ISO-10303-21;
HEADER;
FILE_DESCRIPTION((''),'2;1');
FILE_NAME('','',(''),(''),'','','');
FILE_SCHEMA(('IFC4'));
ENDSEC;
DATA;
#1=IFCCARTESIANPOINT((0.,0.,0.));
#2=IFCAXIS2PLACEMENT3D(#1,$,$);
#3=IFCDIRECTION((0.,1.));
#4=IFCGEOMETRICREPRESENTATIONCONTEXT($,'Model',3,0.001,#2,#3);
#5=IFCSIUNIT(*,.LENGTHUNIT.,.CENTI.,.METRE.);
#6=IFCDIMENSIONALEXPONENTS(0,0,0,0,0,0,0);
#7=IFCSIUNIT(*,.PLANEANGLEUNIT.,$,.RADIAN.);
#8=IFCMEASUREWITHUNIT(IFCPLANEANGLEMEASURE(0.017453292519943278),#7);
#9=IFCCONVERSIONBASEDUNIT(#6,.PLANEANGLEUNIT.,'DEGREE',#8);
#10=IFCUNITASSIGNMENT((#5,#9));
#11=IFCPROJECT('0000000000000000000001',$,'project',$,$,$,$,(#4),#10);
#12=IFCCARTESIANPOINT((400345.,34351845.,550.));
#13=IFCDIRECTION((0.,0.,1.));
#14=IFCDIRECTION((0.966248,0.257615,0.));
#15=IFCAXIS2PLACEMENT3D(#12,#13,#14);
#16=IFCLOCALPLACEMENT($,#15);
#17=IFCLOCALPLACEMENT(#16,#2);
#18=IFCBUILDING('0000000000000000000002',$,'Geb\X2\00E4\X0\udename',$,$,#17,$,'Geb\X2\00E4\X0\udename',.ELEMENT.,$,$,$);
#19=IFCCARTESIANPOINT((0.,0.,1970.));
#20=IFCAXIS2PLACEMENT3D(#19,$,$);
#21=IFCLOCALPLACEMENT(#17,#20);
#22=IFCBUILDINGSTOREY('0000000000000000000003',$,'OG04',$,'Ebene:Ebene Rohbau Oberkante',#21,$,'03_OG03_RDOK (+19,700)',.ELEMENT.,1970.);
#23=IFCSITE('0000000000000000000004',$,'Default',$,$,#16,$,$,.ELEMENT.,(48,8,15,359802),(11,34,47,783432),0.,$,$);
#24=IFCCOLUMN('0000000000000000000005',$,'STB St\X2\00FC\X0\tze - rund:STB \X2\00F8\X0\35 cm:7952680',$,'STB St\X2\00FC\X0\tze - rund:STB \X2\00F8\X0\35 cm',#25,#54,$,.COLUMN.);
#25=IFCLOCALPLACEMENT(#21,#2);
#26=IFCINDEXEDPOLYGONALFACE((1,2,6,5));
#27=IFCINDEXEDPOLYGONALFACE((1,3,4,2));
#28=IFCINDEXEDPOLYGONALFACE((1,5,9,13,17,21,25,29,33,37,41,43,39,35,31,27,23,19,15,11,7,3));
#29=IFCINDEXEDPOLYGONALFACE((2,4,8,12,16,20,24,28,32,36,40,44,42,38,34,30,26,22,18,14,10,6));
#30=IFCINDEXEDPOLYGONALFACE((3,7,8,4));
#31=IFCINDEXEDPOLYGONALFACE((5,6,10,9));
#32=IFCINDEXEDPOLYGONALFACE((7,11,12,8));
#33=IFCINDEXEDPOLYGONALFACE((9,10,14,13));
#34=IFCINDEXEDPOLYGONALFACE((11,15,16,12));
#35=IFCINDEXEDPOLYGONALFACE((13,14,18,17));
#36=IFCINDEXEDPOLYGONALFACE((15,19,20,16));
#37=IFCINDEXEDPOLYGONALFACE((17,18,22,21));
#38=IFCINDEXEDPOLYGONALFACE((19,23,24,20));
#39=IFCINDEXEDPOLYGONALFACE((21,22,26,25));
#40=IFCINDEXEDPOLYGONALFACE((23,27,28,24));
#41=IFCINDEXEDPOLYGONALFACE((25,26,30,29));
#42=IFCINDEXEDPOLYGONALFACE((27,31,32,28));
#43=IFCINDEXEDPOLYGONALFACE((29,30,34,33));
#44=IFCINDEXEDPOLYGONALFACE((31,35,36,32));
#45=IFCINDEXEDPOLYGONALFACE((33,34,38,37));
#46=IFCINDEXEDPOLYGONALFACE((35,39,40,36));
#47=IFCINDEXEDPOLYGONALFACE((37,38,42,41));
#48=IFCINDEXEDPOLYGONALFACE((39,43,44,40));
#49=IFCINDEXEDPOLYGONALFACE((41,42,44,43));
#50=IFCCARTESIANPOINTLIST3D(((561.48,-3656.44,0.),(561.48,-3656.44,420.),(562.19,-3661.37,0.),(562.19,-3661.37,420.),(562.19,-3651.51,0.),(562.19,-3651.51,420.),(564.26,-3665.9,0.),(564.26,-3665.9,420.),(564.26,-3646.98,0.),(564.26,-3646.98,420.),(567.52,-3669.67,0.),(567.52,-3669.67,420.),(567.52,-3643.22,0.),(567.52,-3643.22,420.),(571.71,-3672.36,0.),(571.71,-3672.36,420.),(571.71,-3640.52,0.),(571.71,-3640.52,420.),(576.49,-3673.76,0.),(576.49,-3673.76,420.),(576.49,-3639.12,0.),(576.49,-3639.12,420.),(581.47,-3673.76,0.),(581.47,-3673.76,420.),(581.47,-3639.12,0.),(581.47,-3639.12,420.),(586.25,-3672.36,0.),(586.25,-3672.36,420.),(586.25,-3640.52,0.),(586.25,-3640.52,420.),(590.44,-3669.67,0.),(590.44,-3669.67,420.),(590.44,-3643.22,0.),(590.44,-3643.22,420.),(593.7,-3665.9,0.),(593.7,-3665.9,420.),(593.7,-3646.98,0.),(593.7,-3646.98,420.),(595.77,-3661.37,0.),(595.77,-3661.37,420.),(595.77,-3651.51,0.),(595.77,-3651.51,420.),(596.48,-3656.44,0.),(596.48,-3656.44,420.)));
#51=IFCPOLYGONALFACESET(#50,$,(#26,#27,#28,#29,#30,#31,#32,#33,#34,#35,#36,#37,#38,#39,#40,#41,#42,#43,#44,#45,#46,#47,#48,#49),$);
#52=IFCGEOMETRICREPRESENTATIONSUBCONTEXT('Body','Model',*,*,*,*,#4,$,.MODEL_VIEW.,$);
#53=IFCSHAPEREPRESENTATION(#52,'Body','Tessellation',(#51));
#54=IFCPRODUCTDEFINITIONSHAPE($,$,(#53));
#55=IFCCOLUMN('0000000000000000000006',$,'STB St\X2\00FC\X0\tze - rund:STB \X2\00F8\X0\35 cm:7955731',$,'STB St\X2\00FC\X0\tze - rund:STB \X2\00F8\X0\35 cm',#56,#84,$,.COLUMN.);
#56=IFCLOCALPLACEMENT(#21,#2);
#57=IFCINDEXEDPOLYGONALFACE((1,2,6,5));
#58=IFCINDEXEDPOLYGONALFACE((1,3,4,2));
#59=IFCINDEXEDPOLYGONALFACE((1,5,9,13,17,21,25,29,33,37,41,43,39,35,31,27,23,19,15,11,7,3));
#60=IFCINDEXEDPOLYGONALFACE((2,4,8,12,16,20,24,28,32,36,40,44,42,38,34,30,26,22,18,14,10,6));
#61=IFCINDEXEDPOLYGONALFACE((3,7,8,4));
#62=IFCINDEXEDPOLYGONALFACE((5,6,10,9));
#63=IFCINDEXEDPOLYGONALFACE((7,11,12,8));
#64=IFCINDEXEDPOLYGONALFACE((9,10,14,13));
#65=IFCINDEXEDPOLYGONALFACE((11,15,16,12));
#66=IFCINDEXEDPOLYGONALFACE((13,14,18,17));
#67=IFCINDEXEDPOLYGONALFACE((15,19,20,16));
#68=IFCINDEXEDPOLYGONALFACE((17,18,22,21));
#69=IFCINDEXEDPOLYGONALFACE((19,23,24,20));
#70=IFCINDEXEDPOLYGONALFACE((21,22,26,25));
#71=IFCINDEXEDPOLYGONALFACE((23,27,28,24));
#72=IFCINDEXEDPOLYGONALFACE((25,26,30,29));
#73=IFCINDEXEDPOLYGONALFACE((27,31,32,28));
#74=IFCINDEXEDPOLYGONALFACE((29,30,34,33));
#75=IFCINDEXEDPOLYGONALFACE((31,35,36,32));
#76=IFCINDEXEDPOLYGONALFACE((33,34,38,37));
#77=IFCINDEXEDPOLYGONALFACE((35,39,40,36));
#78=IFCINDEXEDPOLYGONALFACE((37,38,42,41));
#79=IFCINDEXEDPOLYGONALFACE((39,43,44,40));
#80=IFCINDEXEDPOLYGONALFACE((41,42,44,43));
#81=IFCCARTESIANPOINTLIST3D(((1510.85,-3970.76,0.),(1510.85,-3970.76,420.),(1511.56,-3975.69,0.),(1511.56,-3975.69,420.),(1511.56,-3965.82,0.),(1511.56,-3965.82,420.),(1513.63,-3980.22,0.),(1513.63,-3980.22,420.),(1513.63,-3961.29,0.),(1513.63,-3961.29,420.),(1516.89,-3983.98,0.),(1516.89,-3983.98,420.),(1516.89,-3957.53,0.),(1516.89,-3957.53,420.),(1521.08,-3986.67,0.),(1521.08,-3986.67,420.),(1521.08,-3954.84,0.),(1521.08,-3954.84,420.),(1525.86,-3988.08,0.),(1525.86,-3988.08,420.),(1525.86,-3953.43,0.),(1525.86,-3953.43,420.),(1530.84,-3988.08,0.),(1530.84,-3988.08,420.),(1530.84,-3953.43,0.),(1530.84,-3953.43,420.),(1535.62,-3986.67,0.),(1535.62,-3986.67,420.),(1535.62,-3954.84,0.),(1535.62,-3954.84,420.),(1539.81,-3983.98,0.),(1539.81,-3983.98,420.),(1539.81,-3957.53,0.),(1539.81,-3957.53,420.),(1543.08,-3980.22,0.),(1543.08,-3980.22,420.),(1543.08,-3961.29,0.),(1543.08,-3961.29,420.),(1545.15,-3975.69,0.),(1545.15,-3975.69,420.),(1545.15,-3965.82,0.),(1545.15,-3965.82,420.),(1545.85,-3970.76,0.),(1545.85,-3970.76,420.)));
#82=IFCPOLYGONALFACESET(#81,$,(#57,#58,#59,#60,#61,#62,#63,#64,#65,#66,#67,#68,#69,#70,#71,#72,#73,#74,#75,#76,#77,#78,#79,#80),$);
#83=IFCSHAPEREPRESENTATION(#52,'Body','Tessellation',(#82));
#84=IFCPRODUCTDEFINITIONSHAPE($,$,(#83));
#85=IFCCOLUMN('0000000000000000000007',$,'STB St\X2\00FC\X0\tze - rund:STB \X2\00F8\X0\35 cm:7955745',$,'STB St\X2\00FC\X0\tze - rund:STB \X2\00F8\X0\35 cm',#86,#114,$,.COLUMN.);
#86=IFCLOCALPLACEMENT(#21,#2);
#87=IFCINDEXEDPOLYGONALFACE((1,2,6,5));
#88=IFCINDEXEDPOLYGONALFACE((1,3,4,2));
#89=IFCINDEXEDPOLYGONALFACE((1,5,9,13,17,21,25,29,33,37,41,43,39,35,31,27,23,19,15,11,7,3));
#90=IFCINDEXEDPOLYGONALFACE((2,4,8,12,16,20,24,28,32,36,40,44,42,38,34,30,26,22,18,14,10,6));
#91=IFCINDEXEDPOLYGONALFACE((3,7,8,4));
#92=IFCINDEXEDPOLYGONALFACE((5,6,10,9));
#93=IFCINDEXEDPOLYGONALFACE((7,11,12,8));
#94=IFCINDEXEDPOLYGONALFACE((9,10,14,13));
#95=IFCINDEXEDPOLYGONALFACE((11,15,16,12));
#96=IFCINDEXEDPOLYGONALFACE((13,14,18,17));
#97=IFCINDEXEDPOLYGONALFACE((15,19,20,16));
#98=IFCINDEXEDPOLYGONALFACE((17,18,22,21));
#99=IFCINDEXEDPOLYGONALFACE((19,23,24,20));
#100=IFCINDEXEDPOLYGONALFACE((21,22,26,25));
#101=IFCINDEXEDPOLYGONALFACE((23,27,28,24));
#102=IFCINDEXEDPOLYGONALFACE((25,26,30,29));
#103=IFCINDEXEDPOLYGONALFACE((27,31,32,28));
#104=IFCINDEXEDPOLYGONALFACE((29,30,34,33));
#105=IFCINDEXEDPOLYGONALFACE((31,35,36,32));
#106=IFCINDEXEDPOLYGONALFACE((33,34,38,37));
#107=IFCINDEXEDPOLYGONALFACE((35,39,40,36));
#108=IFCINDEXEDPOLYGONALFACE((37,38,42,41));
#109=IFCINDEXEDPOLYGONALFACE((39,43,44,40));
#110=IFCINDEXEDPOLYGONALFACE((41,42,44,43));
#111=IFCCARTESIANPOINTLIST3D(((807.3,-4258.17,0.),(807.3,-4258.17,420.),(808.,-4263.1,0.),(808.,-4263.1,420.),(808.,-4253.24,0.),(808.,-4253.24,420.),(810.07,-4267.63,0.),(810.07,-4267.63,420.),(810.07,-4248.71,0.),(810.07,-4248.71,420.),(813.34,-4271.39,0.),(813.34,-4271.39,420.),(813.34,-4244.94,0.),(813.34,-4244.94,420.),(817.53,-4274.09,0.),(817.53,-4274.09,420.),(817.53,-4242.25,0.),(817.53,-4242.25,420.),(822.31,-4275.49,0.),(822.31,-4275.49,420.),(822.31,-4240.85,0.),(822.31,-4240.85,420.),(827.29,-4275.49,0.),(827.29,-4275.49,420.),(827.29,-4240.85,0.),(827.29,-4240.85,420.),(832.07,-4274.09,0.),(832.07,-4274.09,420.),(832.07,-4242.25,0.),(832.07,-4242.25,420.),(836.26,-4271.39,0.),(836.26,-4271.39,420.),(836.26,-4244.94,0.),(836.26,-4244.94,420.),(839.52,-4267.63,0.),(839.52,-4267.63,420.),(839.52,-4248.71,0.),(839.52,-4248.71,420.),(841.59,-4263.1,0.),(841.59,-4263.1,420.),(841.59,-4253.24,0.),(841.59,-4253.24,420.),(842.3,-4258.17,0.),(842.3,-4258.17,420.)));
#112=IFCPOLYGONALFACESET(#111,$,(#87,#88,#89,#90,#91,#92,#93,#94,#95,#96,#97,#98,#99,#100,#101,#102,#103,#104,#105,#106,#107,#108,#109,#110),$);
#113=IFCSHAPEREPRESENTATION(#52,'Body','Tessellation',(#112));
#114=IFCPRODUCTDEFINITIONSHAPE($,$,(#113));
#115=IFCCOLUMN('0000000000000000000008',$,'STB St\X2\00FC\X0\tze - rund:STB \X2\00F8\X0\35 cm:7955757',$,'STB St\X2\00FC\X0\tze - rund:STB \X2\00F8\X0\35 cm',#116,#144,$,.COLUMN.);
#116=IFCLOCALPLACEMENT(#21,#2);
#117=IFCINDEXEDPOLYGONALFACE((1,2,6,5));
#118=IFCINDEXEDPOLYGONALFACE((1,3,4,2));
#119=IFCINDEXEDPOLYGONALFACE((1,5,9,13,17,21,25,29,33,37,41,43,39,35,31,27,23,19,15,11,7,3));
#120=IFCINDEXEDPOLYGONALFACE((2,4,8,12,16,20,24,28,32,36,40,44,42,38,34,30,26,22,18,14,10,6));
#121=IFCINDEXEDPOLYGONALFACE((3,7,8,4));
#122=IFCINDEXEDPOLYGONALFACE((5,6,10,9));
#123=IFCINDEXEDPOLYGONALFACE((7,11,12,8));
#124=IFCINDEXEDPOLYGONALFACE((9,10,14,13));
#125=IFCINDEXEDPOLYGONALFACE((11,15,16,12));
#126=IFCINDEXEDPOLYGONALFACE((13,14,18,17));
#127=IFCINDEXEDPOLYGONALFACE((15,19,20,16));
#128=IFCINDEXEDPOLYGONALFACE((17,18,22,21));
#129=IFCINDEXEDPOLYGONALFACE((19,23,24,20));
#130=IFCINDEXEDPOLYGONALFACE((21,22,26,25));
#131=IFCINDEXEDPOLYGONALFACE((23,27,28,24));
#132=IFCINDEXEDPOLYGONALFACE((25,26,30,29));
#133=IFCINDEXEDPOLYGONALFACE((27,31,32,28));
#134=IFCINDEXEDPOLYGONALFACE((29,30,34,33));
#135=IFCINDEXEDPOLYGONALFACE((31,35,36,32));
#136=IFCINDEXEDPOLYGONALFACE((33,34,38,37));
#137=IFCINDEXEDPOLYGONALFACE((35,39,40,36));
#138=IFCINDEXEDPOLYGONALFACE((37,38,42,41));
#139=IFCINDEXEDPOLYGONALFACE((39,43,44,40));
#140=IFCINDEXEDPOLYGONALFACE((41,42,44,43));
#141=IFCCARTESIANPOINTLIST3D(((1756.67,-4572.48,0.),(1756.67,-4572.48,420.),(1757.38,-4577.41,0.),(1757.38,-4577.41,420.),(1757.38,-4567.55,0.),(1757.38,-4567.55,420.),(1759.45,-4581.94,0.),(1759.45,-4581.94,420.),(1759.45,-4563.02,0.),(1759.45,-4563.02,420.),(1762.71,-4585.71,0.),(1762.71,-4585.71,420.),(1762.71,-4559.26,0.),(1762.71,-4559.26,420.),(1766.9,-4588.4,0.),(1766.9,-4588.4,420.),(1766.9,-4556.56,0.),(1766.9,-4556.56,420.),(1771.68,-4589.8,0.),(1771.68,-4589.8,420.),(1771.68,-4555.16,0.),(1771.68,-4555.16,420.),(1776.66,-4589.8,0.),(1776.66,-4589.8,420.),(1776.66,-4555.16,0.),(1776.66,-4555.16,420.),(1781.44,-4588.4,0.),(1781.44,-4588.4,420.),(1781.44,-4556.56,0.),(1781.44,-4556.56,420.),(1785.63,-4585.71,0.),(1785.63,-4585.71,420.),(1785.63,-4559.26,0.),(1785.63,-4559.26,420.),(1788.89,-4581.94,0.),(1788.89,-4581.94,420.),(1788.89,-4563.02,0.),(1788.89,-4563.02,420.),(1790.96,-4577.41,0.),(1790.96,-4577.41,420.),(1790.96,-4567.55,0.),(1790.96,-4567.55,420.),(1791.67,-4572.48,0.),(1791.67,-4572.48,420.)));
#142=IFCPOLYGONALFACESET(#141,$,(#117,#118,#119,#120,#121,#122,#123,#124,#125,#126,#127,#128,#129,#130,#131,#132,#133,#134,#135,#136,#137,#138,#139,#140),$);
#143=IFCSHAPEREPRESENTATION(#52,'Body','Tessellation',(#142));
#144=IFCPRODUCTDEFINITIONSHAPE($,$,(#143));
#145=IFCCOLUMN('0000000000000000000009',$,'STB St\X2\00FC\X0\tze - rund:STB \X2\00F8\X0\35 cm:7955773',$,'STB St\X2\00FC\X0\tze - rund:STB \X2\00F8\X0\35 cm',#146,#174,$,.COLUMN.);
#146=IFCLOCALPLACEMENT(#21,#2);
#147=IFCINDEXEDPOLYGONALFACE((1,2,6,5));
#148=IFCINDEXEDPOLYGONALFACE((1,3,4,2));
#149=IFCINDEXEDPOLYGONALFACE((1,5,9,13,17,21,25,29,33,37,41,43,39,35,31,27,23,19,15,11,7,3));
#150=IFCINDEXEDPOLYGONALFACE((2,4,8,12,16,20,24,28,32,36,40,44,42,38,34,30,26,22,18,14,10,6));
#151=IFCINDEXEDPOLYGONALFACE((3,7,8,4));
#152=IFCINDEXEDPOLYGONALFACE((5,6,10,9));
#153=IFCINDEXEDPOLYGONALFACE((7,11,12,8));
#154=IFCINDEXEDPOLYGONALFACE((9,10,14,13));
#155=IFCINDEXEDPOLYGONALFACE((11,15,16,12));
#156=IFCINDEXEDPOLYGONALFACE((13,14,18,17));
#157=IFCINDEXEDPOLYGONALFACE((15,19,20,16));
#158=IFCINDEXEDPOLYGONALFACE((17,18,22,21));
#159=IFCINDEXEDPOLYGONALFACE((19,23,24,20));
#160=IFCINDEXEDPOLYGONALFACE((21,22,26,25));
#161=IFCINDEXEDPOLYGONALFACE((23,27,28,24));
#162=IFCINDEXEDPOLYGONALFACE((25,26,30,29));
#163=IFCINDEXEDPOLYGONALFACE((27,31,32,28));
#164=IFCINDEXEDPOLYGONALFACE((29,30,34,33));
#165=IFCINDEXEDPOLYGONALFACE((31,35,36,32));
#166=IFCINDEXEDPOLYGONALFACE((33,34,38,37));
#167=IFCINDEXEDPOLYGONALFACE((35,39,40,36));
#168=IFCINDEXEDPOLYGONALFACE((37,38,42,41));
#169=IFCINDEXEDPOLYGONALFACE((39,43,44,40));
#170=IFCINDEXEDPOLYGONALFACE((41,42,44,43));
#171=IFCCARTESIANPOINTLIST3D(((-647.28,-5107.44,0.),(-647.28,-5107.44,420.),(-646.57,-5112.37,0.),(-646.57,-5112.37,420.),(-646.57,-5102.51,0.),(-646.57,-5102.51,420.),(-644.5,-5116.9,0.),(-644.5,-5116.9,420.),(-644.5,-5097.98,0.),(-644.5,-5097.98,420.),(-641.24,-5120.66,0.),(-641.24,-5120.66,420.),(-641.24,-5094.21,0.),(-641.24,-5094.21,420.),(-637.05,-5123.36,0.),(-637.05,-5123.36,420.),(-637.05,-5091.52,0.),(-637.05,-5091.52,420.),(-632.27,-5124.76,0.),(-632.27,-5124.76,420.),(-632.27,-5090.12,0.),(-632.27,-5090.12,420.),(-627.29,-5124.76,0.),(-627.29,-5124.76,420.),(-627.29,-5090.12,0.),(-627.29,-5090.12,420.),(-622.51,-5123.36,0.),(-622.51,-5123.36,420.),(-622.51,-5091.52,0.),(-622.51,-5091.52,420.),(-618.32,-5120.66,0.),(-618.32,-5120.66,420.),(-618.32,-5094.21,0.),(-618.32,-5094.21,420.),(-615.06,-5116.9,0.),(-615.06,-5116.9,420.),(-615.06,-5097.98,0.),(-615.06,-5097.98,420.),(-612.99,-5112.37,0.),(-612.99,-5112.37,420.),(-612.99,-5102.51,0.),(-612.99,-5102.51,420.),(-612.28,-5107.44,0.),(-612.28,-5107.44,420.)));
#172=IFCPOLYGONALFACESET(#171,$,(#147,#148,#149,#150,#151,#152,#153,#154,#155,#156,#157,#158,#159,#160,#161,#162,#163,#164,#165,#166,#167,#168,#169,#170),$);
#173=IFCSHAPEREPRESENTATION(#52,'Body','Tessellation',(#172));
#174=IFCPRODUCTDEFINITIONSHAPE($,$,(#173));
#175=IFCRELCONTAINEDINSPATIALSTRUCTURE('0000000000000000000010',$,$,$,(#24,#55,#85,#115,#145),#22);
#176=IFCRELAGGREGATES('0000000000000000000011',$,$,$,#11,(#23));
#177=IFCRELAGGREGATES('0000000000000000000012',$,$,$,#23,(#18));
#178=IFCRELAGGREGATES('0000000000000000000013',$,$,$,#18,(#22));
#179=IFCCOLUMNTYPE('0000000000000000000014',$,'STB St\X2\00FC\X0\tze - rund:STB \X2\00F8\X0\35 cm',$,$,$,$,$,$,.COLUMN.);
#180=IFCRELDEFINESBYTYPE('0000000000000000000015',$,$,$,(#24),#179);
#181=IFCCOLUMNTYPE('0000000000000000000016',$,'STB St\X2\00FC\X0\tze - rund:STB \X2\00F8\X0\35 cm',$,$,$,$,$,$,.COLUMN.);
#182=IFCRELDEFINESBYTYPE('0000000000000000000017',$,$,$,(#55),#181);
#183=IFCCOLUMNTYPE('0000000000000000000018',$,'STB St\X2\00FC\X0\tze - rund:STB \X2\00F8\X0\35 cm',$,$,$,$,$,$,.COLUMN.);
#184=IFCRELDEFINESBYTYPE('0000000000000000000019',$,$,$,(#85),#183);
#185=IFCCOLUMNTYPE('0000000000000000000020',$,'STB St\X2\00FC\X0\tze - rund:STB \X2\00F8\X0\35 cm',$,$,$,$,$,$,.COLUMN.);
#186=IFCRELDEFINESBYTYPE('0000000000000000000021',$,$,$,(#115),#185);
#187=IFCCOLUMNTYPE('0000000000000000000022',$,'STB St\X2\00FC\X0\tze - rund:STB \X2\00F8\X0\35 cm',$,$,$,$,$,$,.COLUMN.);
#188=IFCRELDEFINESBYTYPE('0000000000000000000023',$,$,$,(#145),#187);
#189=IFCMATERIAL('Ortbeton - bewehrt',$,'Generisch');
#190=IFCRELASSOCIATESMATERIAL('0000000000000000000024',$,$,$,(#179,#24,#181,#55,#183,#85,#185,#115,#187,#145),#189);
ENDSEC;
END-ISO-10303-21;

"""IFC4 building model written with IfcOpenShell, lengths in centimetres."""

from ifc_helpers import new_model, entity, si_unit, converted_unit, direction, frame, origin, place, context, subcontext, project, spatial, arc, indexed_curve, outline, extrude, source, transform, mapped, material, type_object, type_shapes, element, save


model = new_model("IFC4")

# Units and contexts
model_context = context("Model", 3, precision=0.001, world=origin(), true_north=direction((0.0, 1.0)))
body_context = subcontext(model_context, "Body", "Model", "MODEL_VIEW")
ifc_project = project(units=[si_unit("LENGTHUNIT", "METRE", prefix="CENTI"), converted_unit("PLANEANGLEUNIT", "DEGREE", entity("IfcPlaneAngleMeasure", 0.017453292519943278), si_unit("PLANEANGLEUNIT", "RADIAN"), dimensions=[0, 0, 0, 0, 0, 0, 0])], contexts=[model_context])

# Site, building, storey
site_placement = place(None, frame((400345.0, 34351845.0, 550.0), z_axis=(0.0, 0.0, 1.0), x_axis=(0.966248, 0.257615, 0.0)))
site = spatial("IfcSite", under=ifc_project, at=site_placement, Name="Default", CompositionType="ELEMENT", RefLatitude=(48, 8, 15, 359802), RefLongitude=(11, 34, 47, 783432), RefElevation=0.0)
building_placement = place(site_placement, origin())
building = spatial("IfcBuilding", under=site, at=building_placement, Name="Gebäudename", LongName="Gebäudename", CompositionType="ELEMENT")
storey_placement = place(building_placement, frame((0.0, 0.0, 1970.0)))
storey = spatial("IfcBuildingStorey", under=building, at=storey_placement, Name="OG04", ObjectType="Ebene:Ebene Rohbau Oberkante", LongName="03_OG03_RDOK (+19,700)", CompositionType="ELEMENT", Elevation=1970.0)

# Columns
ifc_material = material(Name="Ortbeton - bewehrt", Category="Generisch")
column_type_1 = type_object("IfcColumnType", Name="STB Stütze - rund:STB ø35 cm", PredefinedType="COLUMN", material=ifc_material)
shared_shape_1 = source(origin(), body_context, "Body", "SweptSolid", [
    extrude(outline(indexed_curve([(-17.5, 0.0), (0.0, -17.5), (17.5, 0.0), (0.0, 17.5)], segments=[arc(1, 2, 3), arc(3, 4, 1)], self_intersect=False)), frame((578.98, -3656.44, 1970.0)), (0.0, 0.0, 1.0), 420.0),
])
type_shapes(column_type_1, [shared_shape_1])
column_1_placement = place(storey_placement, frame((0.0, 0.0, -1970.0)))
element("IfcColumn", 1, at=column_1_placement, inside=storey, type_object=column_type_1, material=ifc_material, Name="STB Stütze - rund:STB ø35 cm:7952680", ObjectType="STB Stütze - rund:STB ø35 cm", PredefinedType="COLUMN", context=body_context, shape_type="MappedRepresentation", body=[
    mapped(shared_shape_1, transform((0.0, 0.0, 0.0), scale=1.0)),
])
column_type_2 = type_object("IfcColumnType", Name="STB Stütze - rund:STB ø35 cm", PredefinedType="COLUMN", material=ifc_material)
shared_shape_2 = source(origin(), body_context, "Body", "SweptSolid", [
    extrude(outline(indexed_curve([(-17.5, 0.0), (0.0, -17.5), (17.5, 0.0), (0.0, 17.5)], segments=[arc(1, 2, 3), arc(3, 4, 1)], self_intersect=False)), frame((1528.35, -3970.76, 1970.0)), (0.0, 0.0, 1.0), 420.0),
])
type_shapes(column_type_2, [shared_shape_2])
column_2_placement = place(storey_placement, frame((0.0, 0.0, -1970.0)))
element("IfcColumn", 2, at=column_2_placement, inside=storey, type_object=column_type_2, material=ifc_material, Name="STB Stütze - rund:STB ø35 cm:7955731", ObjectType="STB Stütze - rund:STB ø35 cm", PredefinedType="COLUMN", context=body_context, shape_type="MappedRepresentation", body=[
    mapped(shared_shape_2, transform((0.0, 0.0, 0.0), scale=1.0)),
])
column_type_3 = type_object("IfcColumnType", Name="STB Stütze - rund:STB ø35 cm", PredefinedType="COLUMN", material=ifc_material)
shared_shape_3 = source(origin(), body_context, "Body", "SweptSolid", [
    extrude(outline(indexed_curve([(-17.5, 0.0), (0.0, -17.5), (17.5, 0.0), (0.0, 17.5)], segments=[arc(1, 2, 3), arc(3, 4, 1)], self_intersect=False)), frame((824.8, -4258.17, 1970.0)), (0.0, 0.0, 1.0), 420.0),
])
type_shapes(column_type_3, [shared_shape_3])
column_3_placement = place(storey_placement, frame((0.0, 0.0, -1970.0)))
element("IfcColumn", 3, at=column_3_placement, inside=storey, type_object=column_type_3, material=ifc_material, Name="STB Stütze - rund:STB ø35 cm:7955745", ObjectType="STB Stütze - rund:STB ø35 cm", PredefinedType="COLUMN", context=body_context, shape_type="MappedRepresentation", body=[
    mapped(shared_shape_3, transform((0.0, 0.0, 0.0), scale=1.0)),
])
column_type_4 = type_object("IfcColumnType", Name="STB Stütze - rund:STB ø35 cm", PredefinedType="COLUMN", material=ifc_material)
shared_shape_4 = source(origin(), body_context, "Body", "SweptSolid", [
    extrude(outline(indexed_curve([(-17.5, 0.0), (0.0, -17.5), (17.5, 0.0), (0.0, 17.5)], segments=[arc(1, 2, 3), arc(3, 4, 1)], self_intersect=False)), frame((1774.17, -4572.48, 1970.0)), (0.0, 0.0, 1.0), 420.0),
])
type_shapes(column_type_4, [shared_shape_4])
column_4_placement = place(storey_placement, frame((0.0, 0.0, -1970.0)))
element("IfcColumn", 4, at=column_4_placement, inside=storey, type_object=column_type_4, material=ifc_material, Name="STB Stütze - rund:STB ø35 cm:7955757", ObjectType="STB Stütze - rund:STB ø35 cm", PredefinedType="COLUMN", context=body_context, shape_type="MappedRepresentation", body=[
    mapped(shared_shape_4, transform((0.0, 0.0, 0.0), scale=1.0)),
])
column_type_5 = type_object("IfcColumnType", Name="STB Stütze - rund:STB ø35 cm", PredefinedType="COLUMN", material=ifc_material)
shared_shape_5 = source(origin(), body_context, "Body", "SweptSolid", [
    extrude(outline(indexed_curve([(-17.5, 0.0), (0.0, -17.5), (17.5, 0.0), (0.0, 17.5)], segments=[arc(1, 2, 3), arc(3, 4, 1)], self_intersect=False)), frame((-629.78, -5107.44, 1970.0)), (0.0, 0.0, 1.0), 420.0),
])
type_shapes(column_type_5, [shared_shape_5])
column_5_placement = place(storey_placement, frame((0.0, 0.0, -1970.0)))
element("IfcColumn", 5, at=column_5_placement, inside=storey, type_object=column_type_5, material=ifc_material, Name="STB Stütze - rund:STB ø35 cm:7955773", ObjectType="STB Stütze - rund:STB ø35 cm", PredefinedType="COLUMN", context=body_context, shape_type="MappedRepresentation", body=[
    mapped(shared_shape_5, transform((0.0, 0.0, 0.0), scale=1.0)),
])

save(model, "model.ifc")
